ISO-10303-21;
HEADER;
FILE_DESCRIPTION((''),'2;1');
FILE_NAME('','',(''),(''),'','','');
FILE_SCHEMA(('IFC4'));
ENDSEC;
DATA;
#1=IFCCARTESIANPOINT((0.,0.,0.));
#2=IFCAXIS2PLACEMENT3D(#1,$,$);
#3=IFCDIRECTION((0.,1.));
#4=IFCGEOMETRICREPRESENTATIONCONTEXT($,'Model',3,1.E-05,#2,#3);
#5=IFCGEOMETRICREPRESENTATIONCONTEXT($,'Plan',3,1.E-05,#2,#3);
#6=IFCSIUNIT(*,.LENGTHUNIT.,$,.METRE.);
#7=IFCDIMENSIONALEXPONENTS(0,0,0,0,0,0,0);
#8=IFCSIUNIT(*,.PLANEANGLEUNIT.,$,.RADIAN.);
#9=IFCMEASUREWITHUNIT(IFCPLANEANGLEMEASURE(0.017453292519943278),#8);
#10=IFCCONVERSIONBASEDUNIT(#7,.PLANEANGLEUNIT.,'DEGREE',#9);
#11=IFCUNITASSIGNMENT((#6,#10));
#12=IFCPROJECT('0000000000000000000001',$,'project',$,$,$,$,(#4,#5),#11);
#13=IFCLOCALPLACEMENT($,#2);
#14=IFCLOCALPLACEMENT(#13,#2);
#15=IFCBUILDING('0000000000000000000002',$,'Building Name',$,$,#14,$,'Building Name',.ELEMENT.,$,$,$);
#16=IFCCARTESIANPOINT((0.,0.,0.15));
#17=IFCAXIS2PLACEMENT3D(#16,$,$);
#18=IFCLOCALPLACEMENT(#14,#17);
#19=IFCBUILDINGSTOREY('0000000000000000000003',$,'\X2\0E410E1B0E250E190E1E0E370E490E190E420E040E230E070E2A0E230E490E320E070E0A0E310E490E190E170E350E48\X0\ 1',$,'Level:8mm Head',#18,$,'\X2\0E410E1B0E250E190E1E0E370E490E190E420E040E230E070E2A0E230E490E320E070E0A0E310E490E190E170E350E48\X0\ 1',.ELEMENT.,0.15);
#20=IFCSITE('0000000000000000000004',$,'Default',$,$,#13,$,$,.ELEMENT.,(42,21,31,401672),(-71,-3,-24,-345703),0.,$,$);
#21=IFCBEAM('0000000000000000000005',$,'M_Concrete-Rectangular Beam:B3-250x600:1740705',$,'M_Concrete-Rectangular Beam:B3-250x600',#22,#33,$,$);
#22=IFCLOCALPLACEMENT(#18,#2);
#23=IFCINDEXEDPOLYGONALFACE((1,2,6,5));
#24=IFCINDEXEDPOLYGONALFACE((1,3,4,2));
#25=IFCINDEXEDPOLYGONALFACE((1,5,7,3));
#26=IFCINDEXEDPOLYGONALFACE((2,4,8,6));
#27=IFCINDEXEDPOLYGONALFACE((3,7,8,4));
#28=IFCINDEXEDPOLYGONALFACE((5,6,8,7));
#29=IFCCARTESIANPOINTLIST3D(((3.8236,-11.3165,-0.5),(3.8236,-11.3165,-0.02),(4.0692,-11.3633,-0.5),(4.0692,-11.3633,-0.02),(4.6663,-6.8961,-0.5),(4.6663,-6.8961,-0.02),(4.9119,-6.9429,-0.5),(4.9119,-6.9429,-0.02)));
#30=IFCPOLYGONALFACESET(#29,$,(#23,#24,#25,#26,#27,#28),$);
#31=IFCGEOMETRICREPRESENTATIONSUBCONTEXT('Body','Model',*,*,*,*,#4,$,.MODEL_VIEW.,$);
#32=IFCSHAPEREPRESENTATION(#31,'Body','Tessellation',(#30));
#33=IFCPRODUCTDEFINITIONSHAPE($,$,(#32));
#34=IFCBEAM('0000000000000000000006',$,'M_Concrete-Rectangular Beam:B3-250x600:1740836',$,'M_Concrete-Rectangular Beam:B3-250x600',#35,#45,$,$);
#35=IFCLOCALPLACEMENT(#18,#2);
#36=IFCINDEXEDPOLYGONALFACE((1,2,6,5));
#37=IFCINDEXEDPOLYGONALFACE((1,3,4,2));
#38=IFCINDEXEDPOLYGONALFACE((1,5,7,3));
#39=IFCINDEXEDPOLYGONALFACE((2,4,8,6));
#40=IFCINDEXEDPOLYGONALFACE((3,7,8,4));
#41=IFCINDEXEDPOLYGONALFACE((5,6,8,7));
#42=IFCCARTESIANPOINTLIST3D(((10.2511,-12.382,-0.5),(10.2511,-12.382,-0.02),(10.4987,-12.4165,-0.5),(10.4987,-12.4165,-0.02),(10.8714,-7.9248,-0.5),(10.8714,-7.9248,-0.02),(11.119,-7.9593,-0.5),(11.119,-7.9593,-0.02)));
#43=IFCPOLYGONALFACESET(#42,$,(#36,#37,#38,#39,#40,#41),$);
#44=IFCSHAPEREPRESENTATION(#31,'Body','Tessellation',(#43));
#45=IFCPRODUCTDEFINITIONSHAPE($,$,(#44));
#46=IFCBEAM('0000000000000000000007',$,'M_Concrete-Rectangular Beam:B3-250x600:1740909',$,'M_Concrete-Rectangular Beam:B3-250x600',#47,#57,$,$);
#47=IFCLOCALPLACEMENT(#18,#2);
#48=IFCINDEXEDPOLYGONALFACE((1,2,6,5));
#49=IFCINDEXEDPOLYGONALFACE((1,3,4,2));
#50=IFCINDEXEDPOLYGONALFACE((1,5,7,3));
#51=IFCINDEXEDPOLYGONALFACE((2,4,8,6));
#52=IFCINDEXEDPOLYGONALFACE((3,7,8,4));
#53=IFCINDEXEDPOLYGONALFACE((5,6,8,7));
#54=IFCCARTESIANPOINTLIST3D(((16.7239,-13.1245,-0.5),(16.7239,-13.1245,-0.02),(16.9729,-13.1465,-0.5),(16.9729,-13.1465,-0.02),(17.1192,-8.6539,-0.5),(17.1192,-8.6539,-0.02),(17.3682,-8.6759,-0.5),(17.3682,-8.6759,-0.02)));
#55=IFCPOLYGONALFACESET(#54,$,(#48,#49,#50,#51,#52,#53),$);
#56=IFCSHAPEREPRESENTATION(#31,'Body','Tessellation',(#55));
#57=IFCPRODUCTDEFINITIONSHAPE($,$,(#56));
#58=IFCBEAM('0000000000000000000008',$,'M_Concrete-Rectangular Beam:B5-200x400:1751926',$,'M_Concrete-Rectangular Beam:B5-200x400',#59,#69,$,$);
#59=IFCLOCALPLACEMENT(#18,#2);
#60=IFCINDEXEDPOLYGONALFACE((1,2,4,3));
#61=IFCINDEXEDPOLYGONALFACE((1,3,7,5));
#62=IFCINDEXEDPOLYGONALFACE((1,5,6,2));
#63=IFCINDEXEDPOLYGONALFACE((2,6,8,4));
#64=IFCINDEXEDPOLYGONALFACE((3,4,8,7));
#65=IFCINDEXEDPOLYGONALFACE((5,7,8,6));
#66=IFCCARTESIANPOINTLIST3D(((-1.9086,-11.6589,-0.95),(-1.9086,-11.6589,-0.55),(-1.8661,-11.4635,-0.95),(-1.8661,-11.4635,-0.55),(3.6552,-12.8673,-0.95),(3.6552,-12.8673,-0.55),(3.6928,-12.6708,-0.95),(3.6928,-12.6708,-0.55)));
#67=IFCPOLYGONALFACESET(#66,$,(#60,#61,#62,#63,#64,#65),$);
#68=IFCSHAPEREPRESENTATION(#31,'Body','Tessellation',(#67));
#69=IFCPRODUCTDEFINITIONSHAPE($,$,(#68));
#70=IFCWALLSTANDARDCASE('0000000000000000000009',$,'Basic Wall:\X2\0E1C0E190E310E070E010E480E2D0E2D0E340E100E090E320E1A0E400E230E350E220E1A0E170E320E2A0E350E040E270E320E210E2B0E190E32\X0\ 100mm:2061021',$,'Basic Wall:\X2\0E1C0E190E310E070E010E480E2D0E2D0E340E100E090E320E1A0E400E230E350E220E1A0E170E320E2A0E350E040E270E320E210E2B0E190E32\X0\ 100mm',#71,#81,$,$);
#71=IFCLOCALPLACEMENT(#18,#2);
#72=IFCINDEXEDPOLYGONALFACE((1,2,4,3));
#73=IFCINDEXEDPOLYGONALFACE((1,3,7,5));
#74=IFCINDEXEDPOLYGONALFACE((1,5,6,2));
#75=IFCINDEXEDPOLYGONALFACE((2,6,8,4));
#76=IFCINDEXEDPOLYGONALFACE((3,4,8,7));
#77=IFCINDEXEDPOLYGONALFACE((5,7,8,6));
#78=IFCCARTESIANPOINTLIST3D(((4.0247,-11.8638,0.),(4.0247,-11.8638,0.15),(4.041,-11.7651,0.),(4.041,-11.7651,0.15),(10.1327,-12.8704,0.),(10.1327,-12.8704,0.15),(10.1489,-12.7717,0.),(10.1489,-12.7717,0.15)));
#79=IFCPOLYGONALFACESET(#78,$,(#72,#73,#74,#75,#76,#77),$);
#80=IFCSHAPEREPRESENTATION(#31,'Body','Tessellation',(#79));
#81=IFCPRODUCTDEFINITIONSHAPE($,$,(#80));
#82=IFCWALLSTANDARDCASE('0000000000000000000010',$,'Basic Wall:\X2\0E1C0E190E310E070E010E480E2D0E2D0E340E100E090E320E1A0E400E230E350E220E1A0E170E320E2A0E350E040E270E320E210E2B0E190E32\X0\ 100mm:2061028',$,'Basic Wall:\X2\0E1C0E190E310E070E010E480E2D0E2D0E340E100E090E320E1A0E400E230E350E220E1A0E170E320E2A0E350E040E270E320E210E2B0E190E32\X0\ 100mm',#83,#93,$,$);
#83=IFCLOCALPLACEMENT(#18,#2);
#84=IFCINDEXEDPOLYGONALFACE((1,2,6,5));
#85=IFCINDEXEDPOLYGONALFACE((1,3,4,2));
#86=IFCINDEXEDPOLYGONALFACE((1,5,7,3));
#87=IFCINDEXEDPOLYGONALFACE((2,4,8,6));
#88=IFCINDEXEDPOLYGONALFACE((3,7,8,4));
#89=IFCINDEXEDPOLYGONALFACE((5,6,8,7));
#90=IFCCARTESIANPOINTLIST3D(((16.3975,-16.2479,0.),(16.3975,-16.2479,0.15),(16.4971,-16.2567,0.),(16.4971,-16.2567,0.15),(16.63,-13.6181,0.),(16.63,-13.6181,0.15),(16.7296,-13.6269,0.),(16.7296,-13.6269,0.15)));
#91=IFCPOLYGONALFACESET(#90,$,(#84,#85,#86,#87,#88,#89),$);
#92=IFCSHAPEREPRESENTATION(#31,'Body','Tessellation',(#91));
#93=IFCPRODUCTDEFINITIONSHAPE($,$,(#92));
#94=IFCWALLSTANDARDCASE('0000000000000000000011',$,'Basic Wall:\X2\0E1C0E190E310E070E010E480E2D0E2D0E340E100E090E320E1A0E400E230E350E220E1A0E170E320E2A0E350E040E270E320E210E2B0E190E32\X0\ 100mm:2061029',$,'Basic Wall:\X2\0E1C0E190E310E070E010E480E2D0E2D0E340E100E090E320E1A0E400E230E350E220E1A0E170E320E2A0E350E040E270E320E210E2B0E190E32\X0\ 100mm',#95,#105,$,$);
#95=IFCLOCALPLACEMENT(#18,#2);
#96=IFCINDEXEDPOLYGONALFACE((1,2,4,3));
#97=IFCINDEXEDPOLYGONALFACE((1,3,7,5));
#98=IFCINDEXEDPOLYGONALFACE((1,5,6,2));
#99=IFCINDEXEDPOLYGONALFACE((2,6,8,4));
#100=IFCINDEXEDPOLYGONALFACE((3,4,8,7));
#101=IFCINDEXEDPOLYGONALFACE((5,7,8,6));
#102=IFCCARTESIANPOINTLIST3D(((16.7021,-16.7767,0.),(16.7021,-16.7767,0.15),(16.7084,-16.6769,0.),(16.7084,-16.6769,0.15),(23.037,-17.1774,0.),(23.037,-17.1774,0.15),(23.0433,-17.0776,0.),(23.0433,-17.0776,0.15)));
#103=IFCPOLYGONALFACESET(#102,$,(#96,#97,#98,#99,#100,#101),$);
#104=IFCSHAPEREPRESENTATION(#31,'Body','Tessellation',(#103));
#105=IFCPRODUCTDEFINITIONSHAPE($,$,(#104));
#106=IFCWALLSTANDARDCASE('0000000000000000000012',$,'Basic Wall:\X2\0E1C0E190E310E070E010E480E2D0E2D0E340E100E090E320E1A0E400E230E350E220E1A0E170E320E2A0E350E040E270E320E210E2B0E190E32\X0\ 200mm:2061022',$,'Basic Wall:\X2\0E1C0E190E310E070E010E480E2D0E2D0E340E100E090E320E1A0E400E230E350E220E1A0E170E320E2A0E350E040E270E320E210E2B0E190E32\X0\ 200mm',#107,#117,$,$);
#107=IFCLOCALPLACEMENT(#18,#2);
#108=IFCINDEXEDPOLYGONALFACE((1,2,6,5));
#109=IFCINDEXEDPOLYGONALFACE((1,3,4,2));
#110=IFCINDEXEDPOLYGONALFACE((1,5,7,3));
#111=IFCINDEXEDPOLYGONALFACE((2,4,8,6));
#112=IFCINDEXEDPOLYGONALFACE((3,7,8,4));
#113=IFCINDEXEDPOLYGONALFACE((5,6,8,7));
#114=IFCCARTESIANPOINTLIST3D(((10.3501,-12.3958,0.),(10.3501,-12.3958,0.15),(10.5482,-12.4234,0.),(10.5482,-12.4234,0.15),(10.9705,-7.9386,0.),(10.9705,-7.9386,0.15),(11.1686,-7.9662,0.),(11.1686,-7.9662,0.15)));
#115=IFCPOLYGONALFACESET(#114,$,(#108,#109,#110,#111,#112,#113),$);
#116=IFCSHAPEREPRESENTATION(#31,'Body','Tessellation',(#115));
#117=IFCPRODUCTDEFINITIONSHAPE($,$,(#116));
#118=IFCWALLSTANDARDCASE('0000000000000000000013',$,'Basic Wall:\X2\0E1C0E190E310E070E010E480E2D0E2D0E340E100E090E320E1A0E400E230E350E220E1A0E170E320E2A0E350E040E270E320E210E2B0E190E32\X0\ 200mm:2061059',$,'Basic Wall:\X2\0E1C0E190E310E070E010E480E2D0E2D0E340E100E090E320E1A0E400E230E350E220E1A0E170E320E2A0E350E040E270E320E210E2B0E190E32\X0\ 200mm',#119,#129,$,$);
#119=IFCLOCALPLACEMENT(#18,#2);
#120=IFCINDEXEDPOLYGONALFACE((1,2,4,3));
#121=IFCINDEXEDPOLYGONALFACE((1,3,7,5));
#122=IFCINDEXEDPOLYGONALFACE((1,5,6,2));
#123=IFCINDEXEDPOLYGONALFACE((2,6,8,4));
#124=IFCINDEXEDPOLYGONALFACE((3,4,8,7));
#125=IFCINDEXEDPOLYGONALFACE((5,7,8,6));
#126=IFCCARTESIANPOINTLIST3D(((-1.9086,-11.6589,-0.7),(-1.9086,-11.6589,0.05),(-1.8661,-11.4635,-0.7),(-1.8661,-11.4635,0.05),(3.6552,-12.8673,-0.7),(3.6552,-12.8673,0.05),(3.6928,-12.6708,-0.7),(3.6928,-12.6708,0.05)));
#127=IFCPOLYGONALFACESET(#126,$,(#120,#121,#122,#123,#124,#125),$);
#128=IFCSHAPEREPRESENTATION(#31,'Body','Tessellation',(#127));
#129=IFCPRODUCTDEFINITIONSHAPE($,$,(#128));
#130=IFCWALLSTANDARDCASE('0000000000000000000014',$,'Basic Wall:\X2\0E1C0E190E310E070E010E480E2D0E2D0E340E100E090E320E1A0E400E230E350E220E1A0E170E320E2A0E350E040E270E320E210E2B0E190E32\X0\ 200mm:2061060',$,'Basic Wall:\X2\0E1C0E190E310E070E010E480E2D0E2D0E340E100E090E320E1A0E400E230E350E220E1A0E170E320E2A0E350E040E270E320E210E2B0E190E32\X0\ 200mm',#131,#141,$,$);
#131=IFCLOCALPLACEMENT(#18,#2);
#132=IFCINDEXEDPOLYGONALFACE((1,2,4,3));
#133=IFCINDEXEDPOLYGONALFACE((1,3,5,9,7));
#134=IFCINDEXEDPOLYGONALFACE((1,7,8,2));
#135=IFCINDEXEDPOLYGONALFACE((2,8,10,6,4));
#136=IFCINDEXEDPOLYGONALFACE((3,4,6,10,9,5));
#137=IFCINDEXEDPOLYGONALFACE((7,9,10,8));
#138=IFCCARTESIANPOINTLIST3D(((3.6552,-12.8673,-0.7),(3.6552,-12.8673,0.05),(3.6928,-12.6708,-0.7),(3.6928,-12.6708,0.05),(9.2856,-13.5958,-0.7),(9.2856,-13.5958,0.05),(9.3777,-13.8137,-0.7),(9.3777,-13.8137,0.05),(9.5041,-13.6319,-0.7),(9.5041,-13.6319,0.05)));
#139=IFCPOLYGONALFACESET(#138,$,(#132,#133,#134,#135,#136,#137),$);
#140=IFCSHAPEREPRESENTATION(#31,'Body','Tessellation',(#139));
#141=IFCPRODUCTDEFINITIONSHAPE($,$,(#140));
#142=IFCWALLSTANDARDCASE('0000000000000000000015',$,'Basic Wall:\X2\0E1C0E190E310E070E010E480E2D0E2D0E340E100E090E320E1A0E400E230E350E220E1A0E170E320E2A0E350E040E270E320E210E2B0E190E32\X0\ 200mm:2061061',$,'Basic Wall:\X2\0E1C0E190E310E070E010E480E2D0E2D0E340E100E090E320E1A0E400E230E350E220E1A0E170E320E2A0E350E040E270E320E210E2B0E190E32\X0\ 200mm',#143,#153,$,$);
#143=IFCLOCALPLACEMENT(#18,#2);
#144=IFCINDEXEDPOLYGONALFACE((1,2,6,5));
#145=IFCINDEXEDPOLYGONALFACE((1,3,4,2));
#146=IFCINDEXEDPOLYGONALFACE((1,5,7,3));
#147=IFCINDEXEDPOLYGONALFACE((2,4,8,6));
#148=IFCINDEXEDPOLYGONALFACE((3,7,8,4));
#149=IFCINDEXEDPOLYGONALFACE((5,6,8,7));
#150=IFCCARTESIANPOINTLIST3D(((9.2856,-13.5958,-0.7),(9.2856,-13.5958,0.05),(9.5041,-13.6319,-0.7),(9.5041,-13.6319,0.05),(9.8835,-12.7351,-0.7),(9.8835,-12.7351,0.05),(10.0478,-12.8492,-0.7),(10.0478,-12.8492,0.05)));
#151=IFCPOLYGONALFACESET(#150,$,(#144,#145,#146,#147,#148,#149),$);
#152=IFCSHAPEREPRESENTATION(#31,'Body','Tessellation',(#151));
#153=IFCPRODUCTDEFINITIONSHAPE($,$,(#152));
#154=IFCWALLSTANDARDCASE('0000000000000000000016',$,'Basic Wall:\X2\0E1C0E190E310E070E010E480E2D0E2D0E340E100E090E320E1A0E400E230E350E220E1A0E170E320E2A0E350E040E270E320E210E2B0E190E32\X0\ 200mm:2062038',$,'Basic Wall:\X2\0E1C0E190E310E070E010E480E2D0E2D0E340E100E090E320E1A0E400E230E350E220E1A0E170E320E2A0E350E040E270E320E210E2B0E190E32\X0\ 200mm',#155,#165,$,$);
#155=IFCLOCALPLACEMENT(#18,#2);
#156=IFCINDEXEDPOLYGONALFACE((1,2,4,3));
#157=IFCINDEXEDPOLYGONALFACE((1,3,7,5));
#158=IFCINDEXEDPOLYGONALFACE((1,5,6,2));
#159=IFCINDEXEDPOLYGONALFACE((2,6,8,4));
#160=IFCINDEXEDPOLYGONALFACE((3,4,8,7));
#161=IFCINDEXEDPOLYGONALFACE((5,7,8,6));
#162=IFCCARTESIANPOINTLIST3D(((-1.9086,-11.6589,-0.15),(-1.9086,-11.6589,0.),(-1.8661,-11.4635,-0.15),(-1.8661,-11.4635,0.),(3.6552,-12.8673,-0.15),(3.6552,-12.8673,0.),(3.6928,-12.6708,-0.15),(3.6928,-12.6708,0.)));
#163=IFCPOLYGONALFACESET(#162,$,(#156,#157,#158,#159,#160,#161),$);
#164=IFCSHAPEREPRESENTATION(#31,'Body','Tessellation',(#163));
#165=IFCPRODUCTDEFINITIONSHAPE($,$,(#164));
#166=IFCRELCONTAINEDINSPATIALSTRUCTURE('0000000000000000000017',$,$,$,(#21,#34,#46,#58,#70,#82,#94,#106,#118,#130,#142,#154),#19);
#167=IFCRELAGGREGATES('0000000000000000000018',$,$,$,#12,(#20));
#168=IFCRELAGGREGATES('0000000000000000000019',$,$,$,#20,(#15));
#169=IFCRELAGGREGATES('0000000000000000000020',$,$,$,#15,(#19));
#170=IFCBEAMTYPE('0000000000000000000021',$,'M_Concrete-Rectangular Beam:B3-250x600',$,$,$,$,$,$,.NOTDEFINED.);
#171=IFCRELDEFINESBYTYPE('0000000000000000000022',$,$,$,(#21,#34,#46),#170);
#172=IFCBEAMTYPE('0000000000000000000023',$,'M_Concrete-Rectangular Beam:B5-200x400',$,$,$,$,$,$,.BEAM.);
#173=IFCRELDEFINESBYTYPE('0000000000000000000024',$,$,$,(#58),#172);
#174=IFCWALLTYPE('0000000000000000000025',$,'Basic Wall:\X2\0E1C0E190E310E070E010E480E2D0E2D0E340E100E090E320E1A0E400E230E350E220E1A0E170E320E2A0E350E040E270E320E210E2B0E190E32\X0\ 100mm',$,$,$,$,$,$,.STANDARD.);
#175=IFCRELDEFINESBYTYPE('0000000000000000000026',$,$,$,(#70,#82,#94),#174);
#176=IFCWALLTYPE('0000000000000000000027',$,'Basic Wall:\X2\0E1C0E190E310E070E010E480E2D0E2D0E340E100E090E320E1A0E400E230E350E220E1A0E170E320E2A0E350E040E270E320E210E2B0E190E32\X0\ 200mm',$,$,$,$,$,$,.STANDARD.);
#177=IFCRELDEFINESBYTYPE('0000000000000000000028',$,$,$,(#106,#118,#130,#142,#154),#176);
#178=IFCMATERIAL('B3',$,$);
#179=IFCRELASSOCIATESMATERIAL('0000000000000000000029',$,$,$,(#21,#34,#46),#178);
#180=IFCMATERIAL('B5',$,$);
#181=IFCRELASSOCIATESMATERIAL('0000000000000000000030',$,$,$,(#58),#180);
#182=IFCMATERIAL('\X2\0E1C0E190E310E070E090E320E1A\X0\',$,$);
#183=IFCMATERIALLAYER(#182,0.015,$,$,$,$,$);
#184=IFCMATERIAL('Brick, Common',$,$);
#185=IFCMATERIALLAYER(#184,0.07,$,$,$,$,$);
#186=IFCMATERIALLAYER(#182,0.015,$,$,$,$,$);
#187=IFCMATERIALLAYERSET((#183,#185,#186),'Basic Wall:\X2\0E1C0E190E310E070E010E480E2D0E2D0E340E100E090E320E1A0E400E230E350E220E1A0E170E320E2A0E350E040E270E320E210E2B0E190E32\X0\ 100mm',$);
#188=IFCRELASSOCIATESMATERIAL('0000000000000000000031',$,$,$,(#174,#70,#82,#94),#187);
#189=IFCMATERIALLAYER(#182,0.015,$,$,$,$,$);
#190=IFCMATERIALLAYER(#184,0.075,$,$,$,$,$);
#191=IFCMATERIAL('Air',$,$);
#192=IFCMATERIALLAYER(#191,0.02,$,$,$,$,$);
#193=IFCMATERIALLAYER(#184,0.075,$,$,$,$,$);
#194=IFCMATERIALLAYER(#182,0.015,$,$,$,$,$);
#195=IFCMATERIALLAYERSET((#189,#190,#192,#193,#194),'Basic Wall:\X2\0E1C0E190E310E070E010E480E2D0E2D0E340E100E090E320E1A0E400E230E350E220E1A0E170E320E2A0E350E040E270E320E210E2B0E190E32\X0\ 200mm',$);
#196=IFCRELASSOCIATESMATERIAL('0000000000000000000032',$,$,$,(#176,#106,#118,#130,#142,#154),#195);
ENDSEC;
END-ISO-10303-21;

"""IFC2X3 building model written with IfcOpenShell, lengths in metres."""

from ifc_helpers import new_model, entity, si_unit, converted_unit, direction, frame, frame_2d, origin, place, context, subcontext, project, spatial, polyline, rectangle, outline, extrude, clip, halfspace, material, layer, layer_set, layer_usage, type_object, element, save


model = new_model("IFC2X3")

# Units and contexts
model_context = context("Model", 3, precision=1e-05, world=origin(), true_north=direction((0.0, 1.0)))
plan_context = context("Plan", 3, precision=1e-05, world=origin(), true_north=direction((0.0, 1.0)))
body_context = subcontext(model_context, "Body", "Model", "MODEL_VIEW")
ifc_project = project(units=[si_unit("LENGTHUNIT", "METRE"), converted_unit("PLANEANGLEUNIT", "DEGREE", entity("IfcPlaneAngleMeasure", 0.017453292519943278), si_unit("PLANEANGLEUNIT", "RADIAN"), dimensions=[0, 0, 0, 0, 0, 0, 0])], contexts=[model_context, plan_context])

# Site, building, storey
site_placement = place(None, origin())
site = spatial("IfcSite", under=ifc_project, at=site_placement, Name="Default", CompositionType="ELEMENT", RefLatitude=(42, 21, 31, 401672), RefLongitude=(-71, -3, -24, -345703), RefElevation=0.0)
building_placement = place(site_placement, origin())
building = spatial("IfcBuilding", under=site, at=building_placement, Name="Building Name", LongName="Building Name", CompositionType="ELEMENT")
storey_placement = place(building_placement, frame((0.0, 0.0, 0.15)))
storey = spatial("IfcBuildingStorey", under=building, at=storey_placement, Name="แปลนพื้นโครงสร้างชั้นที่ 1", ObjectType="Level:8mm Head", LongName="แปลนพื้นโครงสร้างชั้นที่ 1", CompositionType="ELEMENT", Elevation=0.15)

# Beams
ifc_material_1 = material(Name="B3")
beam_type_1 = type_object("IfcBeamType", Name="M_Concrete-Rectangular Beam:B3-250x600", PredefinedType="NOTDEFINED")
beam_1_placement = place(storey_placement, frame((3.9464, -11.3399, 0.0), z_axis=(0.0, 0.0, 1.0), x_axis=(0.187257, 0.982311, 0.0)))
element("IfcBeam", 1, at=beam_1_placement, inside=storey, type_object=beam_type_1, material=ifc_material_1, Name="M_Concrete-Rectangular Beam:B3-250x600:1740705", ObjectType="M_Concrete-Rectangular Beam:B3-250x600", context=body_context, shape_type="SweptSolid", body=[
    extrude(rectangle(XDim=0.48, YDim=0.25, at=frame_2d((0.0, 0.0), x_axis=(1.0, 0.0))), frame((0.0, 0.0, -0.26), z_axis=(1.0, 0.0, 0.0), x_axis=(0.0, 0.0, -1.0)), (0.0, 0.0, 1.0), 4.5),
])
beam_2_placement = place(storey_placement, frame((10.3404, -12.6469, 0.0), z_axis=(0.0, 0.0, 1.0), x_axis=(0.137844, 0.990454, 0.0)))
element("IfcBeam", 2, at=beam_2_placement, inside=storey, type_object=beam_type_1, material=ifc_material_1, Name="M_Concrete-Rectangular Beam:B3-250x600:1740836", ObjectType="M_Concrete-Rectangular Beam:B3-250x600", context=body_context, shape_type="SweptSolid", body=[
    extrude(rectangle(XDim=0.48, YDim=0.25, at=frame_2d((0.0, 0.0), x_axis=(1.0, 0.0))), frame((0.25, 0.0, -0.26), z_axis=(1.0, 0.0, 0.0), x_axis=(0.0, 0.0, -1.0)), (0.0, 0.0, 1.0), 4.5002),
])
beam_3_placement = place(storey_placement, frame((16.8264, -13.3845, 0.0), z_axis=(0.0, 0.0, 1.0), x_axis=(0.088086, 0.996113, 0.0)))
element("IfcBeam", 3, at=beam_3_placement, inside=storey, type_object=beam_type_1, material=ifc_material_1, Name="M_Concrete-Rectangular Beam:B3-250x600:1740909", ObjectType="M_Concrete-Rectangular Beam:B3-250x600", context=body_context, shape_type="SweptSolid", body=[
    extrude(rectangle(XDim=0.48, YDim=0.25, at=frame_2d((0.0, 0.0), x_axis=(1.0, 0.0))), frame((0.25, 0.0, -0.26), z_axis=(1.0, 0.0, 0.0), x_axis=(0.0, 0.0, -1.0)), (0.0, 0.0, 1.0), 4.4881),
])
ifc_material_2 = material(Name="B5")
beam_type_2 = type_object("IfcBeamType", Name="M_Concrete-Rectangular Beam:B5-200x400", PredefinedType="BEAM")
beam_4_placement = place(storey_placement, frame((3.6552, -12.8673, -0.55), z_axis=(0.0, 0.0, 1.0), x_axis=(-0.977217, 0.212242, 0.0)))
element("IfcBeam", 4, at=beam_4_placement, inside=storey, type_object=beam_type_2, material=ifc_material_2, Name="M_Concrete-Rectangular Beam:B5-200x400:1751926", ObjectType="M_Concrete-Rectangular Beam:B5-200x400", context=body_context, shape_type="Clipping", body=[
    clip(extrude(rectangle(XDim=0.4, YDim=0.2, at=frame_2d((0.0, 0.0), x_axis=(1.0, 0.0))), frame((0.0, -0.1, -0.2), z_axis=(1.0, 0.0, 0.0), x_axis=(0.0, 0.0, -1.0)), (0.0, 0.0, 1.0), 5.6935), halfspace(frame((0.005, -0.2, 0.0), z_axis=(-0.999688, -0.024982, 0.0), x_axis=(0.024982, -0.999688, 0.0)), False)),
])

# Walls
ifc_material_3 = material(Name="ผนังฉาบ")
ifc_layer_1 = layer(ifc_material_3, 0.015)
ifc_material_4 = material(Name="Brick, Common")
ifc_layer_2 = layer(ifc_material_4, 0.07)
ifc_layer_3 = layer(ifc_material_3, 0.015)
ifc_layer_set_1 = layer_set([ifc_layer_1, ifc_layer_2, ifc_layer_3], Name="Basic Wall:ผนังก่ออิฐฉาบเรียบทาสีความหนา 100mm")
ifc_layer_usage_1 = layer_usage(ifc_layer_set_1, "AXIS2", "POSITIVE", -0.05)
wall_type_1 = type_object("IfcWallType", Name="Basic Wall:ผนังก่ออิฐฉาบเรียบทาสีความหนา 100mm", PredefinedType="STANDARD", material=ifc_layer_set_1)
wall_1_placement = place(storey_placement, frame((4.0328, -11.8145, 0.0), z_axis=(0.0, 0.0, 1.0), x_axis=(0.986692, -0.162602, 0.0)))
element("IfcWallStandardCase", 5, at=wall_1_placement, inside=storey, type_object=wall_type_1, material=ifc_layer_usage_1, Name="Basic Wall:ผนังก่ออิฐฉาบเรียบทาสีความหนา 100mm:2061021", ObjectType="Basic Wall:ผนังก่ออิฐฉาบเรียบทาสีความหนา 100mm", context=body_context, shape_type="Clipping", body=[
    clip(extrude(rectangle(XDim=6.1903, YDim=0.1, at=frame_2d((3.0952, 0.0), x_axis=(-1.0, 0.0))), origin(), (0.0, 0.0, 1.0), 0.15), halfspace(origin(), True)),
])
ifc_layer_usage_2 = layer_usage(ifc_layer_set_1, "AXIS2", "POSITIVE", -0.05)
wall_2_placement = place(storey_placement, frame((16.6798, -13.6225, 0.0), z_axis=(0.0, 0.0, 1.0), x_axis=(-0.088086, -0.996113, 0.0)))
element("IfcWallStandardCase", 6, at=wall_2_placement, inside=storey, type_object=wall_type_1, material=ifc_layer_usage_2, Name="Basic Wall:ผนังก่ออิฐฉาบเรียบทาสีความหนา 100mm:2061028", ObjectType="Basic Wall:ผนังก่ออิฐฉาบเรียบทาสีความหนา 100mm", context=body_context, shape_type="Clipping", body=[
    clip(extrude(rectangle(XDim=2.64, YDim=0.1, at=frame_2d((1.32, 0.0), x_axis=(-1.0, 0.0))), origin(), (0.0, 0.0, 1.0), 0.15), halfspace(origin(), True)),
])
ifc_layer_usage_3 = layer_usage(ifc_layer_set_1, "AXIS2", "POSITIVE", -0.05)
wall_3_placement = place(storey_placement, frame((16.7052, -16.7268, 0.0), z_axis=(0.0, 0.0, 1.0), x_axis=(0.998006, -0.063116, 0.0)))
element("IfcWallStandardCase", 7, at=wall_3_placement, inside=storey, type_object=wall_type_1, material=ifc_layer_usage_3, Name="Basic Wall:ผนังก่ออิฐฉาบเรียบทาสีความหนา 100mm:2061029", ObjectType="Basic Wall:ผนังก่ออิฐฉาบเรียบทาสีความหนา 100mm", context=body_context, shape_type="Clipping", body=[
    clip(extrude(rectangle(XDim=6.3476, YDim=0.1, at=frame_2d((3.1738, 0.0), x_axis=(-1.0, 0.0))), origin(), (0.0, 0.0, 1.0), 0.15), halfspace(origin(), True)),
])
ifc_layer_4 = layer(ifc_material_3, 0.015)
ifc_layer_5 = layer(ifc_material_4, 0.075)
ifc_material_5 = material(Name="Air")
ifc_layer_6 = layer(ifc_material_5, 0.02)
ifc_layer_7 = layer(ifc_material_4, 0.075)
ifc_layer_8 = layer(ifc_material_3, 0.015)
ifc_layer_set_2 = layer_set([ifc_layer_4, ifc_layer_5, ifc_layer_6, ifc_layer_7, ifc_layer_8], Name="Basic Wall:ผนังก่ออิฐฉาบเรียบทาสีความหนา 200mm")
ifc_layer_usage_4 = layer_usage(ifc_layer_set_2, "AXIS2", "POSITIVE", -0.1)
wall_type_2 = type_object("IfcWallType", Name="Basic Wall:ผนังก่ออิฐฉาบเรียบทาสีความหนา 200mm", PredefinedType="STANDARD", material=ifc_layer_set_2)
wall_4_placement = place(storey_placement, frame((10.4492, -12.4096, 0.0), z_axis=(0.0, 0.0, 1.0), x_axis=(0.137844, 0.990454, 0.0)))
element("IfcWallStandardCase", 8, at=wall_4_placement, inside=storey, type_object=wall_type_2, material=ifc_layer_usage_4, Name="Basic Wall:ผนังก่ออิฐฉาบเรียบทาสีความหนา 200mm:2061022", ObjectType="Basic Wall:ผนังก่ออิฐฉาบเรียบทาสีความหนา 200mm", context=body_context, shape_type="Clipping", body=[
    clip(extrude(rectangle(XDim=4.5002, YDim=0.2, at=frame_2d((2.2501, 0.0), x_axis=(-1.0, 0.0))), origin(), (0.0, 0.0, 1.0), 0.15), halfspace(origin(), True)),
])
ifc_layer_usage_5 = layer_usage(ifc_layer_set_2, "AXIS2", "NEGATIVE", 0.1)
wall_5_placement = place(storey_placement, frame((3.6765, -12.7696, -0.7), z_axis=(0.0, 0.0, 1.0), x_axis=(-0.977217, 0.212242, 0.0)))
element("IfcWallStandardCase", 9, at=wall_5_placement, inside=storey, type_object=wall_type_2, material=ifc_layer_usage_5, Name="Basic Wall:ผนังก่ออิฐฉาบเรียบทาสีความหนา 200mm:2061059", ObjectType="Basic Wall:ผนังก่ออิฐฉาบเรียบทาสีความหนา 200mm", context=body_context, shape_type="SweptSolid", body=[
    extrude(outline(polyline([(5.6935, -0.1), (5.6935, 0.1), (0.0, 0.1), (0.005, -0.1), (5.6935, -0.1)])), origin(), (0.0, 0.0, 1.0), 0.75),
])
ifc_layer_usage_6 = layer_usage(ifc_layer_set_2, "AXIS2", "NEGATIVE", 0.1)
wall_6_placement = place(storey_placement, frame((9.4877, -13.7306, -0.7), z_axis=(0.0, 0.0, 1.0), x_axis=(-0.986599, 0.163166, 0.0)))
element("IfcWallStandardCase", 10, at=wall_6_placement, inside=storey, type_object=wall_type_2, material=ifc_layer_usage_6, Name="Basic Wall:ผนังก่ออิฐฉาบเรียบทาสีความหนา 200mm:2061060", ObjectType="Basic Wall:ผนังก่ออิฐฉาบเรียบทาสีความหนา 200mm", context=body_context, shape_type="SweptSolid", body=[
    extrude(outline(polyline([(5.8902, -0.1), (5.8952, 0.1), (0.0949, 0.1), (0.0, -0.1), (0.2214, -0.1), (5.8902, -0.1)])), origin(), (0.0, 0.0, 1.0), 0.75),
])
ifc_layer_usage_7 = layer_usage(ifc_layer_set_2, "AXIS2", "NEGATIVE", 0.1)
wall_7_placement = place(storey_placement, frame((9.9656, -12.7922, -0.7), z_axis=(0.0, 0.0, 1.0), x_axis=(-0.570524, -0.821281, 0.0)))
element("IfcWallStandardCase", 11, at=wall_7_placement, inside=storey, type_object=wall_type_2, material=ifc_layer_usage_7, Name="Basic Wall:ผนังก่ออิฐฉาบเรียบทาสีความหนา 200mm:2061061", ObjectType="Basic Wall:ผนังก่ออิฐฉาบเรียบทาสีความหนา 200mm", context=body_context, shape_type="SweptSolid", body=[
    extrude(outline(polyline([(1.048, -0.1), (0.953, 0.1), (0.0, 0.1), (0.0, -0.1), (1.048, -0.1)])), origin(), (0.0, 0.0, 1.0), 0.75),
])
ifc_layer_usage_8 = layer_usage(ifc_layer_set_2, "AXIS2", "NEGATIVE", 0.1)
wall_8_placement = place(storey_placement, frame((3.6765, -12.7696, -0.15), z_axis=(0.0, 0.0, 1.0), x_axis=(-0.977217, 0.212242, 0.0)))
element("IfcWallStandardCase", 12, at=wall_8_placement, inside=storey, type_object=wall_type_2, material=ifc_layer_usage_8, Name="Basic Wall:ผนังก่ออิฐฉาบเรียบทาสีความหนา 200mm:2062038", ObjectType="Basic Wall:ผนังก่ออิฐฉาบเรียบทาสีความหนา 200mm", context=body_context, shape_type="SweptSolid", body=[
    extrude(outline(polyline([(5.6935, -0.1), (5.6935, 0.1), (0.0, 0.1), (0.005, -0.1), (5.6935, -0.1)])), origin(), (0.0, 0.0, 1.0), 0.15),
])

save(model, "model.ifc")
